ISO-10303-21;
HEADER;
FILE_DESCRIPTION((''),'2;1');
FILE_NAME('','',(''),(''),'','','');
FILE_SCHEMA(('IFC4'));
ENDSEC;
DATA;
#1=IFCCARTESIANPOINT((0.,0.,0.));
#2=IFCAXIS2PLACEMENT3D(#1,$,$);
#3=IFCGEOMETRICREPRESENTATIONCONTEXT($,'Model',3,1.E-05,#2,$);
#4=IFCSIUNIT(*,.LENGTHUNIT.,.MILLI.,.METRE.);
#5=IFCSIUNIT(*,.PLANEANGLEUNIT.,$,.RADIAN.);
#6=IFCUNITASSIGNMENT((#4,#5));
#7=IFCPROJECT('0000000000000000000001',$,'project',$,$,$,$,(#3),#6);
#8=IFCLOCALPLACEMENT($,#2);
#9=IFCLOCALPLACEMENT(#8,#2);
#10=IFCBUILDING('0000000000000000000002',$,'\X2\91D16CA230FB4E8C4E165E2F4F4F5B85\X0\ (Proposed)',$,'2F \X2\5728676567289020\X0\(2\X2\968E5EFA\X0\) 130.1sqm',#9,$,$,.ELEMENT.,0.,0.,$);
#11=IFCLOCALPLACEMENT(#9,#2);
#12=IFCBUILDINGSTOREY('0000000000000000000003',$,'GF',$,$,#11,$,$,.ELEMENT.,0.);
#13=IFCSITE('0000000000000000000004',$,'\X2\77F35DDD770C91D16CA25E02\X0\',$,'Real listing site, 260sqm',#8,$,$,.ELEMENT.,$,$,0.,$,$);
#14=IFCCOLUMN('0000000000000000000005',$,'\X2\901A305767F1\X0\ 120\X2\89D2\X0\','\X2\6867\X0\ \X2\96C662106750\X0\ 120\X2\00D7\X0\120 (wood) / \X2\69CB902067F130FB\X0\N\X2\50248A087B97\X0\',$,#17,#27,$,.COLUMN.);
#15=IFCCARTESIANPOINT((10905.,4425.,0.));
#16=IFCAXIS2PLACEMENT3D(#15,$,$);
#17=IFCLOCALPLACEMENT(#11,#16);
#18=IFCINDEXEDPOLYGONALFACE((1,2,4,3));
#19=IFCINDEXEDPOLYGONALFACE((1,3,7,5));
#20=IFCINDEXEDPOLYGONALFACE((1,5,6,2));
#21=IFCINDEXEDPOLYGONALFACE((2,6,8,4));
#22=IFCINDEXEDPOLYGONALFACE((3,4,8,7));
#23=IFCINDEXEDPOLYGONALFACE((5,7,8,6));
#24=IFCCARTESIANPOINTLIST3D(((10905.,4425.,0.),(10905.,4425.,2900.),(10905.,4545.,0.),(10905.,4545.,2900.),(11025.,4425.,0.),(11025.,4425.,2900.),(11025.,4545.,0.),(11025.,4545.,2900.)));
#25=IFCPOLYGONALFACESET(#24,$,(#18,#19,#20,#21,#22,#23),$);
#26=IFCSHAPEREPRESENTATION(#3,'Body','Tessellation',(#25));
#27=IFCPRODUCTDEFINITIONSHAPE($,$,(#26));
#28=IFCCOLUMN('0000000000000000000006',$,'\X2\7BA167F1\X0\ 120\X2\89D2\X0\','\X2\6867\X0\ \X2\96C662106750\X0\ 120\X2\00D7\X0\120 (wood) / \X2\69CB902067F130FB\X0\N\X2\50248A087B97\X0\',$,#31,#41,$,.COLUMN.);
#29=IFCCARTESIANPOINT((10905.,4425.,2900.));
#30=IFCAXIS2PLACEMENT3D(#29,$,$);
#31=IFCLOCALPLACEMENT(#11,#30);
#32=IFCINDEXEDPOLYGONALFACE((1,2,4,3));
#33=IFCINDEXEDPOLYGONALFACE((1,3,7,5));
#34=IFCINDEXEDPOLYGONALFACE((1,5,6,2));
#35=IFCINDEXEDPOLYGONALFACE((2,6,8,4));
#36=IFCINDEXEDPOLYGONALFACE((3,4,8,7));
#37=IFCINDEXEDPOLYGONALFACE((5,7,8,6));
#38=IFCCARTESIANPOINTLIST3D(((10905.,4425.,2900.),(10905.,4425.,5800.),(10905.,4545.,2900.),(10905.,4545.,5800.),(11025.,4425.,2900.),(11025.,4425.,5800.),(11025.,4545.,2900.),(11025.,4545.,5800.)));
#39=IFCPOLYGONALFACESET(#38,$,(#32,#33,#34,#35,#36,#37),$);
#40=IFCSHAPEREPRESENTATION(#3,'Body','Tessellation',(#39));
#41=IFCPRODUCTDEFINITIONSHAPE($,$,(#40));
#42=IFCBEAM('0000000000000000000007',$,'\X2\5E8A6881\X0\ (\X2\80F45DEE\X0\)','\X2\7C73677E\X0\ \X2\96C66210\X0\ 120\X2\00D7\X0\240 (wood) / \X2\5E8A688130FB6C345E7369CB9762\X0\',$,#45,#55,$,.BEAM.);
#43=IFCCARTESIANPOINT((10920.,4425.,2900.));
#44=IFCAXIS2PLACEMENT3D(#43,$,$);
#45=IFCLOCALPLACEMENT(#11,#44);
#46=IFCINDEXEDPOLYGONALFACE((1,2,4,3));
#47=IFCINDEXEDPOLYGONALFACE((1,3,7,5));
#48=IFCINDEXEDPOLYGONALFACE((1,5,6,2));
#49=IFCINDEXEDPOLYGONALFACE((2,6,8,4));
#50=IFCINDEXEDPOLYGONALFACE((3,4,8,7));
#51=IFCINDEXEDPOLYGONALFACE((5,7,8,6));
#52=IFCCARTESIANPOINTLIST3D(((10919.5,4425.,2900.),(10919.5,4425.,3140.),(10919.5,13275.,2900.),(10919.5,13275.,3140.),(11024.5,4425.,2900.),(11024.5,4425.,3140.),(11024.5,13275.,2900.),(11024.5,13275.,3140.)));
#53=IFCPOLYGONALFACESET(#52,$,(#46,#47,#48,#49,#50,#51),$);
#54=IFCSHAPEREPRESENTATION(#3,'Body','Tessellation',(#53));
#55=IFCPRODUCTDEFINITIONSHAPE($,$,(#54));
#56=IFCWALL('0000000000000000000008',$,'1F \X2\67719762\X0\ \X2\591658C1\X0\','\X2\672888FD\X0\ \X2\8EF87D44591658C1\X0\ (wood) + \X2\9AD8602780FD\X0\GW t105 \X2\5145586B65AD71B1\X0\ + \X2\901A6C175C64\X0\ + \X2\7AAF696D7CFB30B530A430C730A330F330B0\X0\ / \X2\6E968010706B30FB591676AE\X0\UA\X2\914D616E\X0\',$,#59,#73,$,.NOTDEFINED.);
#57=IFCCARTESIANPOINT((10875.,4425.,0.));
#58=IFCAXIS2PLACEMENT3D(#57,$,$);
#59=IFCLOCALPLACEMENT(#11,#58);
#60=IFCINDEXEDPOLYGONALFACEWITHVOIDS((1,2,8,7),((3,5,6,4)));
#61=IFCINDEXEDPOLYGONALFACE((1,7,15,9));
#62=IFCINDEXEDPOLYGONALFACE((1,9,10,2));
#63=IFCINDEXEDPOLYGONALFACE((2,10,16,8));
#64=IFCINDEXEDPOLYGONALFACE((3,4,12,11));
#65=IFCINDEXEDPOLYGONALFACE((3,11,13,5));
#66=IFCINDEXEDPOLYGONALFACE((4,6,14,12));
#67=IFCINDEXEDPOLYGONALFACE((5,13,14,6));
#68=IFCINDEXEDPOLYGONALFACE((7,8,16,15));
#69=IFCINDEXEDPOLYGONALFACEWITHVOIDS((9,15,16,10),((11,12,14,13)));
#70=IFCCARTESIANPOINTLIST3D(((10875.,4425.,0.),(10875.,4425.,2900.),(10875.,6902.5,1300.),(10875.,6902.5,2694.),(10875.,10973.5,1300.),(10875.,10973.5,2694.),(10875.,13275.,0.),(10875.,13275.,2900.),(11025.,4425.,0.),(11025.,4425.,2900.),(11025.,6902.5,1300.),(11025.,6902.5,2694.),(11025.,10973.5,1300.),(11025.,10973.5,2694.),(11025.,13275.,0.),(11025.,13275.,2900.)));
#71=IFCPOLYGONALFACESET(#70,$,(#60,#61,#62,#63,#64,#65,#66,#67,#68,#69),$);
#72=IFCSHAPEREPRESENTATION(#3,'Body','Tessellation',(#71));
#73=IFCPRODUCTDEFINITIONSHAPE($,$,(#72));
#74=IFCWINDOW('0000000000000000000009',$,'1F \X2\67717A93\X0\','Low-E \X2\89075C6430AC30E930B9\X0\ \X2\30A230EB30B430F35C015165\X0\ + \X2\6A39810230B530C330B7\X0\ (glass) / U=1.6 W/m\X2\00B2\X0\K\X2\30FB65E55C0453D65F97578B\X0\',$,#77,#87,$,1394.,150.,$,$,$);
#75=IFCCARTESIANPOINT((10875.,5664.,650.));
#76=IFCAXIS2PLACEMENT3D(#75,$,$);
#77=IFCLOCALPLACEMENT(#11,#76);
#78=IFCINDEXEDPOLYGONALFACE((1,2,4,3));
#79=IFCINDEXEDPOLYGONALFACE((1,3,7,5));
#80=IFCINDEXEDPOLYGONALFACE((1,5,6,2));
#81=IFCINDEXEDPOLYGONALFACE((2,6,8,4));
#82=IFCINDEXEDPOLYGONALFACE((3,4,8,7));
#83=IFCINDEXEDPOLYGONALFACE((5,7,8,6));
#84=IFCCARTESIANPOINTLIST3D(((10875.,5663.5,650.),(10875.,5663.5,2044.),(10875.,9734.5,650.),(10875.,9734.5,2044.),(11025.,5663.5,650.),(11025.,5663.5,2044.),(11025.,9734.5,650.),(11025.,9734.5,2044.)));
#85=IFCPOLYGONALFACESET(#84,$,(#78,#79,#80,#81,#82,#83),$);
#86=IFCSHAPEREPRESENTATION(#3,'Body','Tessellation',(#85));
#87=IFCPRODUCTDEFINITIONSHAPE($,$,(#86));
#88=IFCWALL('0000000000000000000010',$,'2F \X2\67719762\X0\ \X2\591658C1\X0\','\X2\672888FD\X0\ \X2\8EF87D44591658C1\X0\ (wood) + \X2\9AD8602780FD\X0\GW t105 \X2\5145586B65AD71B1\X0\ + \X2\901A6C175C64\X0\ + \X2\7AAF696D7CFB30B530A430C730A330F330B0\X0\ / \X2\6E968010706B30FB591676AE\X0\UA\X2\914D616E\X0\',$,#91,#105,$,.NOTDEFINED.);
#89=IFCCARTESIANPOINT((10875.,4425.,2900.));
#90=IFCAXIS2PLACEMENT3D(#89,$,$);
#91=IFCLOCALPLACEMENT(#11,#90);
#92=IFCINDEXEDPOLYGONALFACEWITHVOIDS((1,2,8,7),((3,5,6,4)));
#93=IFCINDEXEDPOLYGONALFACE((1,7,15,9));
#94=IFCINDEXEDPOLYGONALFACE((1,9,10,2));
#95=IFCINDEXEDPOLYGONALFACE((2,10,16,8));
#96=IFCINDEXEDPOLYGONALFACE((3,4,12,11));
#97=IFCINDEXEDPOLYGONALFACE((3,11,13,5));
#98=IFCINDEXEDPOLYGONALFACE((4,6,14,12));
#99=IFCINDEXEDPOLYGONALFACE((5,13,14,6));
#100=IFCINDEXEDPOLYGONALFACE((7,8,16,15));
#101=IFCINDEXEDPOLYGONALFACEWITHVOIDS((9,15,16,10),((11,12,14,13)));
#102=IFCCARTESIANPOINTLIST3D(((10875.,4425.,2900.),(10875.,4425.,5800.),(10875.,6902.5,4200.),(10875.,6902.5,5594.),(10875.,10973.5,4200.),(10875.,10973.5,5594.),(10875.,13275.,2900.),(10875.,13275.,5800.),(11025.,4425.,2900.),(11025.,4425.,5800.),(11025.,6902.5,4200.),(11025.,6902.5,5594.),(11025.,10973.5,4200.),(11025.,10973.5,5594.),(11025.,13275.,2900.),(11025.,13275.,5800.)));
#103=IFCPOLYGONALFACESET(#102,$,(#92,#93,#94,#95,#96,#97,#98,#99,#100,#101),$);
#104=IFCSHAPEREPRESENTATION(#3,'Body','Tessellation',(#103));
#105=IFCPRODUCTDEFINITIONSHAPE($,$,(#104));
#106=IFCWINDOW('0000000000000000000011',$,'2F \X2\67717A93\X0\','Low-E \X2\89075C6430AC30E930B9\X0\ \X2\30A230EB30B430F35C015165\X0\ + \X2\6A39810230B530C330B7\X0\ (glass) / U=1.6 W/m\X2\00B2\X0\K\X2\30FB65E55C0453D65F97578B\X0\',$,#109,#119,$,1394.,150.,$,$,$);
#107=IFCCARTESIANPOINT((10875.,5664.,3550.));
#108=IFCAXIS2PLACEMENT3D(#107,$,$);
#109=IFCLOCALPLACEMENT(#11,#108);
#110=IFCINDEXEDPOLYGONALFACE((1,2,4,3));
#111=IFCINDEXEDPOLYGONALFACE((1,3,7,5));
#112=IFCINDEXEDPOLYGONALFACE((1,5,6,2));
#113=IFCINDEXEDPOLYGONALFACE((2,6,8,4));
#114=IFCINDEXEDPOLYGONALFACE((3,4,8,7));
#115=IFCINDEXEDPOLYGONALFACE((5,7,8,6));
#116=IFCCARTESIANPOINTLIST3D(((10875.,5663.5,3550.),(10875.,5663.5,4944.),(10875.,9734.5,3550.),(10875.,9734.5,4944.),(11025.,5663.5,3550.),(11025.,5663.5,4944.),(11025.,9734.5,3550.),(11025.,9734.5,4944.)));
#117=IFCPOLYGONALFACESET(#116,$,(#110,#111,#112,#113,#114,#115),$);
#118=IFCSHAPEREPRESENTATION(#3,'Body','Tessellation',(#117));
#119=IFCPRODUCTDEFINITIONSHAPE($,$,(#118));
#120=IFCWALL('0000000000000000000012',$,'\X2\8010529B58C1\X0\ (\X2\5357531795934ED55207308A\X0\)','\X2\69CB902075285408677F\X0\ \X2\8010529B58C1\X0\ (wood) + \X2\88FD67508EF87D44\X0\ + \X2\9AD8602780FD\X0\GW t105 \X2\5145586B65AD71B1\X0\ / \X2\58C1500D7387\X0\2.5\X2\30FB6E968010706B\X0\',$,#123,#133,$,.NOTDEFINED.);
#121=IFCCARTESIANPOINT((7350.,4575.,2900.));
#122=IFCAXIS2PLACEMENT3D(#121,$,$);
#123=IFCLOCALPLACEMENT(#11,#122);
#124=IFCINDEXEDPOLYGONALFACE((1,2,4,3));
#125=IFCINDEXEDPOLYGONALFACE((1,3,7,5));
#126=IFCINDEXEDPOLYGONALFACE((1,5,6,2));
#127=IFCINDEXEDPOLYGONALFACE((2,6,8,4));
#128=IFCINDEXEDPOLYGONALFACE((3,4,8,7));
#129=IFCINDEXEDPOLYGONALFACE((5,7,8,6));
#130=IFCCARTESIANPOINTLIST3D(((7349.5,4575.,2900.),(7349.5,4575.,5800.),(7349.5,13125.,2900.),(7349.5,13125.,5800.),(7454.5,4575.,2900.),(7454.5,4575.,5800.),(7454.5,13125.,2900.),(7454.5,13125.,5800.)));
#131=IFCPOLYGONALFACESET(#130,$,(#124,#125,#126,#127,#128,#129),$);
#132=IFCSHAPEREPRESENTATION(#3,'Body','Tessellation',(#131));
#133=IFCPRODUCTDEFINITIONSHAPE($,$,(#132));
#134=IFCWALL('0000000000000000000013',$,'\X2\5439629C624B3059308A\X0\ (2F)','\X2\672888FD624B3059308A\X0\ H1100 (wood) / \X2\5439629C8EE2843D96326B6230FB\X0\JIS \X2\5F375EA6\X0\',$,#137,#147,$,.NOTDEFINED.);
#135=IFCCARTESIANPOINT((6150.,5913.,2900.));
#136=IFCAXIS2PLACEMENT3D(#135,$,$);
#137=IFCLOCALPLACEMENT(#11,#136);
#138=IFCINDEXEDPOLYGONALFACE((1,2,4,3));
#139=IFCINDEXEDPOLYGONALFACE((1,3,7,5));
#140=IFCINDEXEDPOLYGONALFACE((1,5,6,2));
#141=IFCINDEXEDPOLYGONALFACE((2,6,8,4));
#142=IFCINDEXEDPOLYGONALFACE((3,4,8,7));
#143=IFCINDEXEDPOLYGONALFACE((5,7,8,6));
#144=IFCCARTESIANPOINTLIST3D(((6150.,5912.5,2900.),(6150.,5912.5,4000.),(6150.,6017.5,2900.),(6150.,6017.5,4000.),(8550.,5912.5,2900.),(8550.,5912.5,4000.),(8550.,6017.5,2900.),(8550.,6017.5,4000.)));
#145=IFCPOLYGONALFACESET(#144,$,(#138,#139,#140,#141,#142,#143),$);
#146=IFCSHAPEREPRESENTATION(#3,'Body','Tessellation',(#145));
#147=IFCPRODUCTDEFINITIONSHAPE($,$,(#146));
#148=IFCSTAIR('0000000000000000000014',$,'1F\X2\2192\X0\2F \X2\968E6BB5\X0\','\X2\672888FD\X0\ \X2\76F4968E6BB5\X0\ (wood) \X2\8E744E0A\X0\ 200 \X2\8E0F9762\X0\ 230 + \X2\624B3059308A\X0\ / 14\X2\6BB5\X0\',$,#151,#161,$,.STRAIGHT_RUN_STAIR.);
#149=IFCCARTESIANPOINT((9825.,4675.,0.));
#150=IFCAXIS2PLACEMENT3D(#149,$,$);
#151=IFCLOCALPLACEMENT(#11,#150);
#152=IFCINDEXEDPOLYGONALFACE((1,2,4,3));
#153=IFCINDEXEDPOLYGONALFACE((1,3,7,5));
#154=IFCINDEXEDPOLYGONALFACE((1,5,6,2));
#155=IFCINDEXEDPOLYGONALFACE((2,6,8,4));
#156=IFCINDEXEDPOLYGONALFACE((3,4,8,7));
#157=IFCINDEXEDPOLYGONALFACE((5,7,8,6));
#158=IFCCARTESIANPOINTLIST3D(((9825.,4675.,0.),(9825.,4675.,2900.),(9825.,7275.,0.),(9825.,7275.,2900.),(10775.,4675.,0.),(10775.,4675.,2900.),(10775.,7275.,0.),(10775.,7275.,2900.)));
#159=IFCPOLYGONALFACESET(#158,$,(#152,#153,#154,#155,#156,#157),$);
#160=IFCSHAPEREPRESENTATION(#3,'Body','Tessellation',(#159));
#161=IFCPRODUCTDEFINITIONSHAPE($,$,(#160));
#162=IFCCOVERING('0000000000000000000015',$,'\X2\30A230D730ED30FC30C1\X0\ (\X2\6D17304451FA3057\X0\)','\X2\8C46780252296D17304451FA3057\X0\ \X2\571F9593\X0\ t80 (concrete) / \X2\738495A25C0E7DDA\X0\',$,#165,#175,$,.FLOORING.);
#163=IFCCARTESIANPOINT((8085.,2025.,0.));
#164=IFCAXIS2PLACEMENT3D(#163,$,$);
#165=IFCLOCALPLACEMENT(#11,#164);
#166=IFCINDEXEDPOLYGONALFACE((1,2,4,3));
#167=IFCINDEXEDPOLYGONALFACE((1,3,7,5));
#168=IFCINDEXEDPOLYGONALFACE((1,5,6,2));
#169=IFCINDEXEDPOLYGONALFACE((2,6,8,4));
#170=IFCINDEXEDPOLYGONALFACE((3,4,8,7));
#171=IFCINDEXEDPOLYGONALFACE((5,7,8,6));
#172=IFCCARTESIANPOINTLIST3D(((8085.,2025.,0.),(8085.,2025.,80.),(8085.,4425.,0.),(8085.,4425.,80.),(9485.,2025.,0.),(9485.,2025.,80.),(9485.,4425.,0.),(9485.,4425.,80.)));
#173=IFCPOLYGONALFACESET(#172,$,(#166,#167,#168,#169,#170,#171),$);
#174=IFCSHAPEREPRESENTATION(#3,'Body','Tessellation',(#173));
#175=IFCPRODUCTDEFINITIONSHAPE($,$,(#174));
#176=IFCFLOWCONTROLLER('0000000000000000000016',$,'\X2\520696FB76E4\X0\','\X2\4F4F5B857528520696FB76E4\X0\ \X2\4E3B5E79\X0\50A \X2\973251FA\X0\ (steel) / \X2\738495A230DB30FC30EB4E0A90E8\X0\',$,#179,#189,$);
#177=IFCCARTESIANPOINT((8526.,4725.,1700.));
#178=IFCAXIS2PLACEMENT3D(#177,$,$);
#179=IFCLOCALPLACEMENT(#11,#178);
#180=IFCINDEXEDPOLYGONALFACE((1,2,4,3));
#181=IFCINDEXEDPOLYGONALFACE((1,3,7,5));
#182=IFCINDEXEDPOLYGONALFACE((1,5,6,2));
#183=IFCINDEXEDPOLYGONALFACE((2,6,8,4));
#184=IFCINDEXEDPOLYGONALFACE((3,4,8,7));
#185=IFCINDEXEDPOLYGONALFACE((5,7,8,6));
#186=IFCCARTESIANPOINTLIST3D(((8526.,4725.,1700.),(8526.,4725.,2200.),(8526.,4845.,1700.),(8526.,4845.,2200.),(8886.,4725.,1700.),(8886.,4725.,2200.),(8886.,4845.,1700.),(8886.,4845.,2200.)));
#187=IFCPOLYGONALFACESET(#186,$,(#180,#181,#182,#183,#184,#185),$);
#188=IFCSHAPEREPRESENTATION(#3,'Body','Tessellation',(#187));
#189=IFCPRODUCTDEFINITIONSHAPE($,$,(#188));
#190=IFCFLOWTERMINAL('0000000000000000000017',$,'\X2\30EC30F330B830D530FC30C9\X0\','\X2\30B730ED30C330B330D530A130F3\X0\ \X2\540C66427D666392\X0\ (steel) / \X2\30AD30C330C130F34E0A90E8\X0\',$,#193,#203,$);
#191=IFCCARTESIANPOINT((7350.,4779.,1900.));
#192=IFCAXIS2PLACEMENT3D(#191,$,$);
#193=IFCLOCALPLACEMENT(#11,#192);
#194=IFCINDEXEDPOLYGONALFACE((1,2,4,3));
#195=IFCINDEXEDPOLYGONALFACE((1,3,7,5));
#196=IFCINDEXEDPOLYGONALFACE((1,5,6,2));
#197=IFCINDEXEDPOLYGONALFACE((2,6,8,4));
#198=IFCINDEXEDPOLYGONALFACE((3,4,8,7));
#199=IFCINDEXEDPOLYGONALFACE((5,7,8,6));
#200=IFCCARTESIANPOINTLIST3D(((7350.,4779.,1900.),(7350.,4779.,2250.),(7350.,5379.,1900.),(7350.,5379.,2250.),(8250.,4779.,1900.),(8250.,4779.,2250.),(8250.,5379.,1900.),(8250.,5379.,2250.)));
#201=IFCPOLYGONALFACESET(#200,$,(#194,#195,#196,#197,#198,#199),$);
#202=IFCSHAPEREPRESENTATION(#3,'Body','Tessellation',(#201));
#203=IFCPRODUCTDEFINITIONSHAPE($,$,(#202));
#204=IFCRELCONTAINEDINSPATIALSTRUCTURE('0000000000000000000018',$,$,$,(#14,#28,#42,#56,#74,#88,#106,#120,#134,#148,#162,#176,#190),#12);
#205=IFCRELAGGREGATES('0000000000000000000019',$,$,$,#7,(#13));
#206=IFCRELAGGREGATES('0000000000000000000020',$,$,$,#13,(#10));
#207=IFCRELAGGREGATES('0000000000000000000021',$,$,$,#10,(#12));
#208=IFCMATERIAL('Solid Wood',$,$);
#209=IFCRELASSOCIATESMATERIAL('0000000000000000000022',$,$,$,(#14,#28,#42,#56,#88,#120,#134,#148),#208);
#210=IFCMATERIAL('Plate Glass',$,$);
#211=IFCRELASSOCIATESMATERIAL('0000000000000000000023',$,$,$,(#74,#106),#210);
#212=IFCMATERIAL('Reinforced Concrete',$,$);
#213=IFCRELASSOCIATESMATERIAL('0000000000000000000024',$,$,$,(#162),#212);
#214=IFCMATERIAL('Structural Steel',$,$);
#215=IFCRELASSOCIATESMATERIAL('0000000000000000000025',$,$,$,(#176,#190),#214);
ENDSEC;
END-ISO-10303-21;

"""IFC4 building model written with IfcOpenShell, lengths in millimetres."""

from ifc_helpers import new_model, si_unit, frame, frame_2d, origin, place, context, project, spatial, rectangle, extrude, material, element, fill, save


model = new_model("IFC4")

# Units and contexts
model_context = context("Model", 3, precision=1e-05, world=origin())
ifc_project = project(units=[si_unit("LENGTHUNIT", "METRE", prefix="MILLI"), si_unit("PLANEANGLEUNIT", "RADIAN")], contexts=[model_context])

# Site, building, storey
site_placement = place(None, origin())
site = spatial("IfcSite", under=ifc_project, at=site_placement, Name="石川県金沢市", ObjectType="Real listing site, 260sqm", CompositionType="ELEMENT", RefElevation=0.0)
building_placement = place(site_placement, origin())
building = spatial("IfcBuilding", under=site, at=building_placement, Name="金沢・二世帯住宅 (Proposed)", ObjectType="2F 在来木造(2階建) 130.1sqm", CompositionType="ELEMENT", ElevationOfRefHeight=0.0, ElevationOfTerrain=0.0)
storey_placement = place(building_placement, origin())
storey = spatial("IfcBuildingStorey", under=building, at=storey_placement, Name="GF", CompositionType="ELEMENT", Elevation=0.0)

# Columns
ifc_material_1 = material(Name="Solid Wood")
column_1_placement = place(storey_placement, frame((10905.0, 4425.0, 0.0)))
element("IfcColumn", 1, at=column_1_placement, inside=storey, material=ifc_material_1, Name="通し柱 120角", Description="桧 集成材 120×120 (wood) / 構造柱・N値計算", PredefinedType="COLUMN", context=model_context, shape_type="SweptSolid", body=[
    extrude(rectangle(XDim=120.0, YDim=120.0, at=frame_2d((60.0, 60.0))), frame((10905.0, 4425.0, 0.0)), (0.0, 0.0, 1.0), 2900.0),
])
column_2_placement = place(storey_placement, frame((10905.0, 4425.0, 2900.0)))
element("IfcColumn", 2, at=column_2_placement, inside=storey, material=ifc_material_1, Name="管柱 120角", Description="桧 集成材 120×120 (wood) / 構造柱・N値計算", PredefinedType="COLUMN", context=model_context, shape_type="SweptSolid", body=[
    extrude(rectangle(XDim=120.0, YDim=120.0, at=frame_2d((60.0, 60.0))), frame((10905.0, 4425.0, 2900.0)), (0.0, 0.0, 1.0), 2900.0),
])

# Beam
beam_1_placement = place(storey_placement, frame((10920.0, 4425.0, 2900.0)))
element("IfcBeam", 3, at=beam_1_placement, inside=storey, material=ifc_material_1, Name="床梁 (胴差)", Description="米松 集成 120×240 (wood) / 床梁・水平構面", PredefinedType="BEAM", context=model_context, shape_type="SweptSolid", body=[
    extrude(rectangle(XDim=105.0, YDim=8850.0, at=frame_2d((52.0, 4425.0))), frame((10920.0, 4425.0, 2900.0)), (0.0, 0.0, 1.0), 240.0),
])

# Wall, opening, window
wall_1_placement = place(storey_placement, frame((10875.0, 4425.0, 0.0)))
wall_1 = element("IfcWall", 4, at=wall_1_placement, inside=storey, material=ifc_material_1, Name="1F 東面 外壁", Description="木製 軸組外壁 (wood) + 高性能GW t105 充填断熱 + 通気層 + 窯業系サイディング / 準耐火・外皮UA配慮", PredefinedType="NOTDEFINED", context=model_context, shape_type="SweptSolid", body=[
    extrude(rectangle(XDim=150.0, YDim=8850.0, at=frame_2d((75.0, 4425.0))), frame((10875.0, 4425.0, 0.0)), (0.0, 0.0, 1.0), 2900.0),
])
opening_1_placement = place(storey_placement, frame((10875.0, 5664.0, 650.0)))
opening_1 = element("IfcOpeningElement", 5, at=opening_1_placement, cuts=wall_1, PredefinedType="NOTDEFINED", context=model_context, shape_type="SweptSolid", body=[
    extrude(rectangle(XDim=150.0, YDim=4071.0, at=frame_2d((75.0, 2035.0))), frame((10875.0, 5664.0, 650.0)), (0.0, 0.0, 1.0), 1394.0),
])
ifc_material_2 = material(Name="Plate Glass")
window_1_placement = place(storey_placement, frame((10875.0, 5664.0, 650.0)))
window_1 = element("IfcWindow", 6, at=window_1_placement, inside=storey, material=ifc_material_2, Name="1F 東窓", Description="Low-E 複層ガラス アルゴン封入 + 樹脂サッシ (glass) / U=1.6 W/m²K・日射取得型", OverallHeight=1394.0, OverallWidth=150.0, context=model_context, shape_type="SweptSolid", body=[
    extrude(rectangle(XDim=150.0, YDim=4071.0, at=frame_2d((75.0, 2035.0))), frame((10875.0, 5664.0, 650.0)), (0.0, 0.0, 1.0), 1394.0),
])
fill(opening_1, window_1)

# Wall, opening, window
wall_2_placement = place(storey_placement, frame((10875.0, 4425.0, 2900.0)))
wall_2 = element("IfcWall", 7, at=wall_2_placement, inside=storey, material=ifc_material_1, Name="2F 東面 外壁", Description="木製 軸組外壁 (wood) + 高性能GW t105 充填断熱 + 通気層 + 窯業系サイディング / 準耐火・外皮UA配慮", PredefinedType="NOTDEFINED", context=model_context, shape_type="SweptSolid", body=[
    extrude(rectangle(XDim=150.0, YDim=8850.0, at=frame_2d((75.0, 4425.0))), frame((10875.0, 4425.0, 2900.0)), (0.0, 0.0, 1.0), 2900.0),
])
opening_2_placement = place(storey_placement, frame((10875.0, 5664.0, 3550.0)))
opening_2 = element("IfcOpeningElement", 8, at=opening_2_placement, cuts=wall_2, PredefinedType="NOTDEFINED", context=model_context, shape_type="SweptSolid", body=[
    extrude(rectangle(XDim=150.0, YDim=4071.0, at=frame_2d((75.0, 2035.0))), frame((10875.0, 5664.0, 3550.0)), (0.0, 0.0, 1.0), 1394.0),
])
window_2_placement = place(storey_placement, frame((10875.0, 5664.0, 3550.0)))
window_2 = element("IfcWindow", 9, at=window_2_placement, inside=storey, material=ifc_material_2, Name="2F 東窓", Description="Low-E 複層ガラス アルゴン封入 + 樹脂サッシ (glass) / U=1.6 W/m²K・日射取得型", OverallHeight=1394.0, OverallWidth=150.0, context=model_context, shape_type="SweptSolid", body=[
    extrude(rectangle(XDim=150.0, YDim=4071.0, at=frame_2d((75.0, 2035.0))), frame((10875.0, 5664.0, 3550.0)), (0.0, 0.0, 1.0), 1394.0),
])
fill(opening_2, window_2)

# Walls
wall_3_placement = place(storey_placement, frame((7350.0, 4575.0, 2900.0)))
element("IfcWall", 10, at=wall_3_placement, inside=storey, material=ifc_material_1, Name="耐力壁 (南北間仕切り)", Description="構造用合板 耐力壁 (wood) + 製材軸組 + 高性能GW t105 充填断熱 / 壁倍率2.5・準耐火", PredefinedType="NOTDEFINED", context=model_context, shape_type="SweptSolid", body=[
    extrude(rectangle(XDim=105.0, YDim=8550.0, at=frame_2d((52.0, 4275.0))), frame((7350.0, 4575.0, 2900.0)), (0.0, 0.0, 1.0), 2900.0),
])
wall_4_placement = place(storey_placement, frame((6150.0, 5913.0, 2900.0)))
element("IfcWall", 11, at=wall_4_placement, inside=storey, material=ifc_material_1, Name="吹抜手すり (2F)", Description="木製手すり H1100 (wood) / 吹抜転落防止・JIS 強度", PredefinedType="NOTDEFINED", context=model_context, shape_type="SweptSolid", body=[
    extrude(rectangle(XDim=2400.0, YDim=105.0, at=frame_2d((1200.0, 52.0))), frame((6150.0, 5913.0, 2900.0)), (0.0, 0.0, 1.0), 1100.0),
])

# Stair
stair_placement = place(storey_placement, frame((9825.0, 4675.0, 0.0)))
element("IfcStair", 12, at=stair_placement, inside=storey, material=ifc_material_1, Name="1F→2F 階段", Description="木製 直階段 (wood) 蹴上 200 踏面 230 + 手すり / 14段", PredefinedType="STRAIGHT_RUN_STAIR", context=model_context, shape_type="SweptSolid", body=[
    extrude(rectangle(XDim=950.0, YDim=2600.0, at=frame_2d((475.0, 1300.0))), frame((9825.0, 4675.0, 0.0)), (0.0, 0.0, 1.0), 2900.0),
])

# Covering
ifc_material_3 = material(Name="Reinforced Concrete")
covering_placement = place(storey_placement, frame((8085.0, 2025.0, 0.0)))
element("IfcCovering", 13, at=covering_placement, inside=storey, material=ifc_material_3, Name="アプローチ (洗い出し)", Description="豆砂利洗い出し 土間 t80 (concrete) / 玄関導線", PredefinedType="FLOORING", context=model_context, shape_type="SweptSolid", body=[
    extrude(rectangle(XDim=1400.0, YDim=2400.0, at=frame_2d((700.0, 1200.0))), frame((8085.0, 2025.0, 0.0)), (0.0, 0.0, 1.0), 80.0),
])

# Flow controller
ifc_material_4 = material(Name="Structural Steel")
flow_controller_placement = place(storey_placement, frame((8526.0, 4725.0, 1700.0)))
element("IfcFlowController", 14, at=flow_controller_placement, inside=storey, material=ifc_material_4, Name="分電盤", Description="住宅用分電盤 主幹50A 露出 (steel) / 玄関ホール上部", context=model_context, shape_type="SweptSolid", body=[
    extrude(rectangle(XDim=360.0, YDim=120.0, at=frame_2d((180.0, 60.0))), frame((8526.0, 4725.0, 1700.0)), (0.0, 0.0, 1.0), 500.0),
])

# Flow terminal
flow_terminal_1_placement = place(storey_placement, frame((7350.0, 4779.0, 1900.0)))
element("IfcFlowTerminal", 15, at=flow_terminal_1_placement, inside=storey, material=ifc_material_4, Name="レンジフード", Description="シロッコファン 同時給排 (steel) / キッチン上部", context=model_context, shape_type="SweptSolid", body=[
    extrude(rectangle(XDim=900.0, YDim=600.0, at=frame_2d((450.0, 300.0))), frame((7350.0, 4779.0, 1900.0)), (0.0, 0.0, 1.0), 350.0),
])

save(model, "model.ifc")
